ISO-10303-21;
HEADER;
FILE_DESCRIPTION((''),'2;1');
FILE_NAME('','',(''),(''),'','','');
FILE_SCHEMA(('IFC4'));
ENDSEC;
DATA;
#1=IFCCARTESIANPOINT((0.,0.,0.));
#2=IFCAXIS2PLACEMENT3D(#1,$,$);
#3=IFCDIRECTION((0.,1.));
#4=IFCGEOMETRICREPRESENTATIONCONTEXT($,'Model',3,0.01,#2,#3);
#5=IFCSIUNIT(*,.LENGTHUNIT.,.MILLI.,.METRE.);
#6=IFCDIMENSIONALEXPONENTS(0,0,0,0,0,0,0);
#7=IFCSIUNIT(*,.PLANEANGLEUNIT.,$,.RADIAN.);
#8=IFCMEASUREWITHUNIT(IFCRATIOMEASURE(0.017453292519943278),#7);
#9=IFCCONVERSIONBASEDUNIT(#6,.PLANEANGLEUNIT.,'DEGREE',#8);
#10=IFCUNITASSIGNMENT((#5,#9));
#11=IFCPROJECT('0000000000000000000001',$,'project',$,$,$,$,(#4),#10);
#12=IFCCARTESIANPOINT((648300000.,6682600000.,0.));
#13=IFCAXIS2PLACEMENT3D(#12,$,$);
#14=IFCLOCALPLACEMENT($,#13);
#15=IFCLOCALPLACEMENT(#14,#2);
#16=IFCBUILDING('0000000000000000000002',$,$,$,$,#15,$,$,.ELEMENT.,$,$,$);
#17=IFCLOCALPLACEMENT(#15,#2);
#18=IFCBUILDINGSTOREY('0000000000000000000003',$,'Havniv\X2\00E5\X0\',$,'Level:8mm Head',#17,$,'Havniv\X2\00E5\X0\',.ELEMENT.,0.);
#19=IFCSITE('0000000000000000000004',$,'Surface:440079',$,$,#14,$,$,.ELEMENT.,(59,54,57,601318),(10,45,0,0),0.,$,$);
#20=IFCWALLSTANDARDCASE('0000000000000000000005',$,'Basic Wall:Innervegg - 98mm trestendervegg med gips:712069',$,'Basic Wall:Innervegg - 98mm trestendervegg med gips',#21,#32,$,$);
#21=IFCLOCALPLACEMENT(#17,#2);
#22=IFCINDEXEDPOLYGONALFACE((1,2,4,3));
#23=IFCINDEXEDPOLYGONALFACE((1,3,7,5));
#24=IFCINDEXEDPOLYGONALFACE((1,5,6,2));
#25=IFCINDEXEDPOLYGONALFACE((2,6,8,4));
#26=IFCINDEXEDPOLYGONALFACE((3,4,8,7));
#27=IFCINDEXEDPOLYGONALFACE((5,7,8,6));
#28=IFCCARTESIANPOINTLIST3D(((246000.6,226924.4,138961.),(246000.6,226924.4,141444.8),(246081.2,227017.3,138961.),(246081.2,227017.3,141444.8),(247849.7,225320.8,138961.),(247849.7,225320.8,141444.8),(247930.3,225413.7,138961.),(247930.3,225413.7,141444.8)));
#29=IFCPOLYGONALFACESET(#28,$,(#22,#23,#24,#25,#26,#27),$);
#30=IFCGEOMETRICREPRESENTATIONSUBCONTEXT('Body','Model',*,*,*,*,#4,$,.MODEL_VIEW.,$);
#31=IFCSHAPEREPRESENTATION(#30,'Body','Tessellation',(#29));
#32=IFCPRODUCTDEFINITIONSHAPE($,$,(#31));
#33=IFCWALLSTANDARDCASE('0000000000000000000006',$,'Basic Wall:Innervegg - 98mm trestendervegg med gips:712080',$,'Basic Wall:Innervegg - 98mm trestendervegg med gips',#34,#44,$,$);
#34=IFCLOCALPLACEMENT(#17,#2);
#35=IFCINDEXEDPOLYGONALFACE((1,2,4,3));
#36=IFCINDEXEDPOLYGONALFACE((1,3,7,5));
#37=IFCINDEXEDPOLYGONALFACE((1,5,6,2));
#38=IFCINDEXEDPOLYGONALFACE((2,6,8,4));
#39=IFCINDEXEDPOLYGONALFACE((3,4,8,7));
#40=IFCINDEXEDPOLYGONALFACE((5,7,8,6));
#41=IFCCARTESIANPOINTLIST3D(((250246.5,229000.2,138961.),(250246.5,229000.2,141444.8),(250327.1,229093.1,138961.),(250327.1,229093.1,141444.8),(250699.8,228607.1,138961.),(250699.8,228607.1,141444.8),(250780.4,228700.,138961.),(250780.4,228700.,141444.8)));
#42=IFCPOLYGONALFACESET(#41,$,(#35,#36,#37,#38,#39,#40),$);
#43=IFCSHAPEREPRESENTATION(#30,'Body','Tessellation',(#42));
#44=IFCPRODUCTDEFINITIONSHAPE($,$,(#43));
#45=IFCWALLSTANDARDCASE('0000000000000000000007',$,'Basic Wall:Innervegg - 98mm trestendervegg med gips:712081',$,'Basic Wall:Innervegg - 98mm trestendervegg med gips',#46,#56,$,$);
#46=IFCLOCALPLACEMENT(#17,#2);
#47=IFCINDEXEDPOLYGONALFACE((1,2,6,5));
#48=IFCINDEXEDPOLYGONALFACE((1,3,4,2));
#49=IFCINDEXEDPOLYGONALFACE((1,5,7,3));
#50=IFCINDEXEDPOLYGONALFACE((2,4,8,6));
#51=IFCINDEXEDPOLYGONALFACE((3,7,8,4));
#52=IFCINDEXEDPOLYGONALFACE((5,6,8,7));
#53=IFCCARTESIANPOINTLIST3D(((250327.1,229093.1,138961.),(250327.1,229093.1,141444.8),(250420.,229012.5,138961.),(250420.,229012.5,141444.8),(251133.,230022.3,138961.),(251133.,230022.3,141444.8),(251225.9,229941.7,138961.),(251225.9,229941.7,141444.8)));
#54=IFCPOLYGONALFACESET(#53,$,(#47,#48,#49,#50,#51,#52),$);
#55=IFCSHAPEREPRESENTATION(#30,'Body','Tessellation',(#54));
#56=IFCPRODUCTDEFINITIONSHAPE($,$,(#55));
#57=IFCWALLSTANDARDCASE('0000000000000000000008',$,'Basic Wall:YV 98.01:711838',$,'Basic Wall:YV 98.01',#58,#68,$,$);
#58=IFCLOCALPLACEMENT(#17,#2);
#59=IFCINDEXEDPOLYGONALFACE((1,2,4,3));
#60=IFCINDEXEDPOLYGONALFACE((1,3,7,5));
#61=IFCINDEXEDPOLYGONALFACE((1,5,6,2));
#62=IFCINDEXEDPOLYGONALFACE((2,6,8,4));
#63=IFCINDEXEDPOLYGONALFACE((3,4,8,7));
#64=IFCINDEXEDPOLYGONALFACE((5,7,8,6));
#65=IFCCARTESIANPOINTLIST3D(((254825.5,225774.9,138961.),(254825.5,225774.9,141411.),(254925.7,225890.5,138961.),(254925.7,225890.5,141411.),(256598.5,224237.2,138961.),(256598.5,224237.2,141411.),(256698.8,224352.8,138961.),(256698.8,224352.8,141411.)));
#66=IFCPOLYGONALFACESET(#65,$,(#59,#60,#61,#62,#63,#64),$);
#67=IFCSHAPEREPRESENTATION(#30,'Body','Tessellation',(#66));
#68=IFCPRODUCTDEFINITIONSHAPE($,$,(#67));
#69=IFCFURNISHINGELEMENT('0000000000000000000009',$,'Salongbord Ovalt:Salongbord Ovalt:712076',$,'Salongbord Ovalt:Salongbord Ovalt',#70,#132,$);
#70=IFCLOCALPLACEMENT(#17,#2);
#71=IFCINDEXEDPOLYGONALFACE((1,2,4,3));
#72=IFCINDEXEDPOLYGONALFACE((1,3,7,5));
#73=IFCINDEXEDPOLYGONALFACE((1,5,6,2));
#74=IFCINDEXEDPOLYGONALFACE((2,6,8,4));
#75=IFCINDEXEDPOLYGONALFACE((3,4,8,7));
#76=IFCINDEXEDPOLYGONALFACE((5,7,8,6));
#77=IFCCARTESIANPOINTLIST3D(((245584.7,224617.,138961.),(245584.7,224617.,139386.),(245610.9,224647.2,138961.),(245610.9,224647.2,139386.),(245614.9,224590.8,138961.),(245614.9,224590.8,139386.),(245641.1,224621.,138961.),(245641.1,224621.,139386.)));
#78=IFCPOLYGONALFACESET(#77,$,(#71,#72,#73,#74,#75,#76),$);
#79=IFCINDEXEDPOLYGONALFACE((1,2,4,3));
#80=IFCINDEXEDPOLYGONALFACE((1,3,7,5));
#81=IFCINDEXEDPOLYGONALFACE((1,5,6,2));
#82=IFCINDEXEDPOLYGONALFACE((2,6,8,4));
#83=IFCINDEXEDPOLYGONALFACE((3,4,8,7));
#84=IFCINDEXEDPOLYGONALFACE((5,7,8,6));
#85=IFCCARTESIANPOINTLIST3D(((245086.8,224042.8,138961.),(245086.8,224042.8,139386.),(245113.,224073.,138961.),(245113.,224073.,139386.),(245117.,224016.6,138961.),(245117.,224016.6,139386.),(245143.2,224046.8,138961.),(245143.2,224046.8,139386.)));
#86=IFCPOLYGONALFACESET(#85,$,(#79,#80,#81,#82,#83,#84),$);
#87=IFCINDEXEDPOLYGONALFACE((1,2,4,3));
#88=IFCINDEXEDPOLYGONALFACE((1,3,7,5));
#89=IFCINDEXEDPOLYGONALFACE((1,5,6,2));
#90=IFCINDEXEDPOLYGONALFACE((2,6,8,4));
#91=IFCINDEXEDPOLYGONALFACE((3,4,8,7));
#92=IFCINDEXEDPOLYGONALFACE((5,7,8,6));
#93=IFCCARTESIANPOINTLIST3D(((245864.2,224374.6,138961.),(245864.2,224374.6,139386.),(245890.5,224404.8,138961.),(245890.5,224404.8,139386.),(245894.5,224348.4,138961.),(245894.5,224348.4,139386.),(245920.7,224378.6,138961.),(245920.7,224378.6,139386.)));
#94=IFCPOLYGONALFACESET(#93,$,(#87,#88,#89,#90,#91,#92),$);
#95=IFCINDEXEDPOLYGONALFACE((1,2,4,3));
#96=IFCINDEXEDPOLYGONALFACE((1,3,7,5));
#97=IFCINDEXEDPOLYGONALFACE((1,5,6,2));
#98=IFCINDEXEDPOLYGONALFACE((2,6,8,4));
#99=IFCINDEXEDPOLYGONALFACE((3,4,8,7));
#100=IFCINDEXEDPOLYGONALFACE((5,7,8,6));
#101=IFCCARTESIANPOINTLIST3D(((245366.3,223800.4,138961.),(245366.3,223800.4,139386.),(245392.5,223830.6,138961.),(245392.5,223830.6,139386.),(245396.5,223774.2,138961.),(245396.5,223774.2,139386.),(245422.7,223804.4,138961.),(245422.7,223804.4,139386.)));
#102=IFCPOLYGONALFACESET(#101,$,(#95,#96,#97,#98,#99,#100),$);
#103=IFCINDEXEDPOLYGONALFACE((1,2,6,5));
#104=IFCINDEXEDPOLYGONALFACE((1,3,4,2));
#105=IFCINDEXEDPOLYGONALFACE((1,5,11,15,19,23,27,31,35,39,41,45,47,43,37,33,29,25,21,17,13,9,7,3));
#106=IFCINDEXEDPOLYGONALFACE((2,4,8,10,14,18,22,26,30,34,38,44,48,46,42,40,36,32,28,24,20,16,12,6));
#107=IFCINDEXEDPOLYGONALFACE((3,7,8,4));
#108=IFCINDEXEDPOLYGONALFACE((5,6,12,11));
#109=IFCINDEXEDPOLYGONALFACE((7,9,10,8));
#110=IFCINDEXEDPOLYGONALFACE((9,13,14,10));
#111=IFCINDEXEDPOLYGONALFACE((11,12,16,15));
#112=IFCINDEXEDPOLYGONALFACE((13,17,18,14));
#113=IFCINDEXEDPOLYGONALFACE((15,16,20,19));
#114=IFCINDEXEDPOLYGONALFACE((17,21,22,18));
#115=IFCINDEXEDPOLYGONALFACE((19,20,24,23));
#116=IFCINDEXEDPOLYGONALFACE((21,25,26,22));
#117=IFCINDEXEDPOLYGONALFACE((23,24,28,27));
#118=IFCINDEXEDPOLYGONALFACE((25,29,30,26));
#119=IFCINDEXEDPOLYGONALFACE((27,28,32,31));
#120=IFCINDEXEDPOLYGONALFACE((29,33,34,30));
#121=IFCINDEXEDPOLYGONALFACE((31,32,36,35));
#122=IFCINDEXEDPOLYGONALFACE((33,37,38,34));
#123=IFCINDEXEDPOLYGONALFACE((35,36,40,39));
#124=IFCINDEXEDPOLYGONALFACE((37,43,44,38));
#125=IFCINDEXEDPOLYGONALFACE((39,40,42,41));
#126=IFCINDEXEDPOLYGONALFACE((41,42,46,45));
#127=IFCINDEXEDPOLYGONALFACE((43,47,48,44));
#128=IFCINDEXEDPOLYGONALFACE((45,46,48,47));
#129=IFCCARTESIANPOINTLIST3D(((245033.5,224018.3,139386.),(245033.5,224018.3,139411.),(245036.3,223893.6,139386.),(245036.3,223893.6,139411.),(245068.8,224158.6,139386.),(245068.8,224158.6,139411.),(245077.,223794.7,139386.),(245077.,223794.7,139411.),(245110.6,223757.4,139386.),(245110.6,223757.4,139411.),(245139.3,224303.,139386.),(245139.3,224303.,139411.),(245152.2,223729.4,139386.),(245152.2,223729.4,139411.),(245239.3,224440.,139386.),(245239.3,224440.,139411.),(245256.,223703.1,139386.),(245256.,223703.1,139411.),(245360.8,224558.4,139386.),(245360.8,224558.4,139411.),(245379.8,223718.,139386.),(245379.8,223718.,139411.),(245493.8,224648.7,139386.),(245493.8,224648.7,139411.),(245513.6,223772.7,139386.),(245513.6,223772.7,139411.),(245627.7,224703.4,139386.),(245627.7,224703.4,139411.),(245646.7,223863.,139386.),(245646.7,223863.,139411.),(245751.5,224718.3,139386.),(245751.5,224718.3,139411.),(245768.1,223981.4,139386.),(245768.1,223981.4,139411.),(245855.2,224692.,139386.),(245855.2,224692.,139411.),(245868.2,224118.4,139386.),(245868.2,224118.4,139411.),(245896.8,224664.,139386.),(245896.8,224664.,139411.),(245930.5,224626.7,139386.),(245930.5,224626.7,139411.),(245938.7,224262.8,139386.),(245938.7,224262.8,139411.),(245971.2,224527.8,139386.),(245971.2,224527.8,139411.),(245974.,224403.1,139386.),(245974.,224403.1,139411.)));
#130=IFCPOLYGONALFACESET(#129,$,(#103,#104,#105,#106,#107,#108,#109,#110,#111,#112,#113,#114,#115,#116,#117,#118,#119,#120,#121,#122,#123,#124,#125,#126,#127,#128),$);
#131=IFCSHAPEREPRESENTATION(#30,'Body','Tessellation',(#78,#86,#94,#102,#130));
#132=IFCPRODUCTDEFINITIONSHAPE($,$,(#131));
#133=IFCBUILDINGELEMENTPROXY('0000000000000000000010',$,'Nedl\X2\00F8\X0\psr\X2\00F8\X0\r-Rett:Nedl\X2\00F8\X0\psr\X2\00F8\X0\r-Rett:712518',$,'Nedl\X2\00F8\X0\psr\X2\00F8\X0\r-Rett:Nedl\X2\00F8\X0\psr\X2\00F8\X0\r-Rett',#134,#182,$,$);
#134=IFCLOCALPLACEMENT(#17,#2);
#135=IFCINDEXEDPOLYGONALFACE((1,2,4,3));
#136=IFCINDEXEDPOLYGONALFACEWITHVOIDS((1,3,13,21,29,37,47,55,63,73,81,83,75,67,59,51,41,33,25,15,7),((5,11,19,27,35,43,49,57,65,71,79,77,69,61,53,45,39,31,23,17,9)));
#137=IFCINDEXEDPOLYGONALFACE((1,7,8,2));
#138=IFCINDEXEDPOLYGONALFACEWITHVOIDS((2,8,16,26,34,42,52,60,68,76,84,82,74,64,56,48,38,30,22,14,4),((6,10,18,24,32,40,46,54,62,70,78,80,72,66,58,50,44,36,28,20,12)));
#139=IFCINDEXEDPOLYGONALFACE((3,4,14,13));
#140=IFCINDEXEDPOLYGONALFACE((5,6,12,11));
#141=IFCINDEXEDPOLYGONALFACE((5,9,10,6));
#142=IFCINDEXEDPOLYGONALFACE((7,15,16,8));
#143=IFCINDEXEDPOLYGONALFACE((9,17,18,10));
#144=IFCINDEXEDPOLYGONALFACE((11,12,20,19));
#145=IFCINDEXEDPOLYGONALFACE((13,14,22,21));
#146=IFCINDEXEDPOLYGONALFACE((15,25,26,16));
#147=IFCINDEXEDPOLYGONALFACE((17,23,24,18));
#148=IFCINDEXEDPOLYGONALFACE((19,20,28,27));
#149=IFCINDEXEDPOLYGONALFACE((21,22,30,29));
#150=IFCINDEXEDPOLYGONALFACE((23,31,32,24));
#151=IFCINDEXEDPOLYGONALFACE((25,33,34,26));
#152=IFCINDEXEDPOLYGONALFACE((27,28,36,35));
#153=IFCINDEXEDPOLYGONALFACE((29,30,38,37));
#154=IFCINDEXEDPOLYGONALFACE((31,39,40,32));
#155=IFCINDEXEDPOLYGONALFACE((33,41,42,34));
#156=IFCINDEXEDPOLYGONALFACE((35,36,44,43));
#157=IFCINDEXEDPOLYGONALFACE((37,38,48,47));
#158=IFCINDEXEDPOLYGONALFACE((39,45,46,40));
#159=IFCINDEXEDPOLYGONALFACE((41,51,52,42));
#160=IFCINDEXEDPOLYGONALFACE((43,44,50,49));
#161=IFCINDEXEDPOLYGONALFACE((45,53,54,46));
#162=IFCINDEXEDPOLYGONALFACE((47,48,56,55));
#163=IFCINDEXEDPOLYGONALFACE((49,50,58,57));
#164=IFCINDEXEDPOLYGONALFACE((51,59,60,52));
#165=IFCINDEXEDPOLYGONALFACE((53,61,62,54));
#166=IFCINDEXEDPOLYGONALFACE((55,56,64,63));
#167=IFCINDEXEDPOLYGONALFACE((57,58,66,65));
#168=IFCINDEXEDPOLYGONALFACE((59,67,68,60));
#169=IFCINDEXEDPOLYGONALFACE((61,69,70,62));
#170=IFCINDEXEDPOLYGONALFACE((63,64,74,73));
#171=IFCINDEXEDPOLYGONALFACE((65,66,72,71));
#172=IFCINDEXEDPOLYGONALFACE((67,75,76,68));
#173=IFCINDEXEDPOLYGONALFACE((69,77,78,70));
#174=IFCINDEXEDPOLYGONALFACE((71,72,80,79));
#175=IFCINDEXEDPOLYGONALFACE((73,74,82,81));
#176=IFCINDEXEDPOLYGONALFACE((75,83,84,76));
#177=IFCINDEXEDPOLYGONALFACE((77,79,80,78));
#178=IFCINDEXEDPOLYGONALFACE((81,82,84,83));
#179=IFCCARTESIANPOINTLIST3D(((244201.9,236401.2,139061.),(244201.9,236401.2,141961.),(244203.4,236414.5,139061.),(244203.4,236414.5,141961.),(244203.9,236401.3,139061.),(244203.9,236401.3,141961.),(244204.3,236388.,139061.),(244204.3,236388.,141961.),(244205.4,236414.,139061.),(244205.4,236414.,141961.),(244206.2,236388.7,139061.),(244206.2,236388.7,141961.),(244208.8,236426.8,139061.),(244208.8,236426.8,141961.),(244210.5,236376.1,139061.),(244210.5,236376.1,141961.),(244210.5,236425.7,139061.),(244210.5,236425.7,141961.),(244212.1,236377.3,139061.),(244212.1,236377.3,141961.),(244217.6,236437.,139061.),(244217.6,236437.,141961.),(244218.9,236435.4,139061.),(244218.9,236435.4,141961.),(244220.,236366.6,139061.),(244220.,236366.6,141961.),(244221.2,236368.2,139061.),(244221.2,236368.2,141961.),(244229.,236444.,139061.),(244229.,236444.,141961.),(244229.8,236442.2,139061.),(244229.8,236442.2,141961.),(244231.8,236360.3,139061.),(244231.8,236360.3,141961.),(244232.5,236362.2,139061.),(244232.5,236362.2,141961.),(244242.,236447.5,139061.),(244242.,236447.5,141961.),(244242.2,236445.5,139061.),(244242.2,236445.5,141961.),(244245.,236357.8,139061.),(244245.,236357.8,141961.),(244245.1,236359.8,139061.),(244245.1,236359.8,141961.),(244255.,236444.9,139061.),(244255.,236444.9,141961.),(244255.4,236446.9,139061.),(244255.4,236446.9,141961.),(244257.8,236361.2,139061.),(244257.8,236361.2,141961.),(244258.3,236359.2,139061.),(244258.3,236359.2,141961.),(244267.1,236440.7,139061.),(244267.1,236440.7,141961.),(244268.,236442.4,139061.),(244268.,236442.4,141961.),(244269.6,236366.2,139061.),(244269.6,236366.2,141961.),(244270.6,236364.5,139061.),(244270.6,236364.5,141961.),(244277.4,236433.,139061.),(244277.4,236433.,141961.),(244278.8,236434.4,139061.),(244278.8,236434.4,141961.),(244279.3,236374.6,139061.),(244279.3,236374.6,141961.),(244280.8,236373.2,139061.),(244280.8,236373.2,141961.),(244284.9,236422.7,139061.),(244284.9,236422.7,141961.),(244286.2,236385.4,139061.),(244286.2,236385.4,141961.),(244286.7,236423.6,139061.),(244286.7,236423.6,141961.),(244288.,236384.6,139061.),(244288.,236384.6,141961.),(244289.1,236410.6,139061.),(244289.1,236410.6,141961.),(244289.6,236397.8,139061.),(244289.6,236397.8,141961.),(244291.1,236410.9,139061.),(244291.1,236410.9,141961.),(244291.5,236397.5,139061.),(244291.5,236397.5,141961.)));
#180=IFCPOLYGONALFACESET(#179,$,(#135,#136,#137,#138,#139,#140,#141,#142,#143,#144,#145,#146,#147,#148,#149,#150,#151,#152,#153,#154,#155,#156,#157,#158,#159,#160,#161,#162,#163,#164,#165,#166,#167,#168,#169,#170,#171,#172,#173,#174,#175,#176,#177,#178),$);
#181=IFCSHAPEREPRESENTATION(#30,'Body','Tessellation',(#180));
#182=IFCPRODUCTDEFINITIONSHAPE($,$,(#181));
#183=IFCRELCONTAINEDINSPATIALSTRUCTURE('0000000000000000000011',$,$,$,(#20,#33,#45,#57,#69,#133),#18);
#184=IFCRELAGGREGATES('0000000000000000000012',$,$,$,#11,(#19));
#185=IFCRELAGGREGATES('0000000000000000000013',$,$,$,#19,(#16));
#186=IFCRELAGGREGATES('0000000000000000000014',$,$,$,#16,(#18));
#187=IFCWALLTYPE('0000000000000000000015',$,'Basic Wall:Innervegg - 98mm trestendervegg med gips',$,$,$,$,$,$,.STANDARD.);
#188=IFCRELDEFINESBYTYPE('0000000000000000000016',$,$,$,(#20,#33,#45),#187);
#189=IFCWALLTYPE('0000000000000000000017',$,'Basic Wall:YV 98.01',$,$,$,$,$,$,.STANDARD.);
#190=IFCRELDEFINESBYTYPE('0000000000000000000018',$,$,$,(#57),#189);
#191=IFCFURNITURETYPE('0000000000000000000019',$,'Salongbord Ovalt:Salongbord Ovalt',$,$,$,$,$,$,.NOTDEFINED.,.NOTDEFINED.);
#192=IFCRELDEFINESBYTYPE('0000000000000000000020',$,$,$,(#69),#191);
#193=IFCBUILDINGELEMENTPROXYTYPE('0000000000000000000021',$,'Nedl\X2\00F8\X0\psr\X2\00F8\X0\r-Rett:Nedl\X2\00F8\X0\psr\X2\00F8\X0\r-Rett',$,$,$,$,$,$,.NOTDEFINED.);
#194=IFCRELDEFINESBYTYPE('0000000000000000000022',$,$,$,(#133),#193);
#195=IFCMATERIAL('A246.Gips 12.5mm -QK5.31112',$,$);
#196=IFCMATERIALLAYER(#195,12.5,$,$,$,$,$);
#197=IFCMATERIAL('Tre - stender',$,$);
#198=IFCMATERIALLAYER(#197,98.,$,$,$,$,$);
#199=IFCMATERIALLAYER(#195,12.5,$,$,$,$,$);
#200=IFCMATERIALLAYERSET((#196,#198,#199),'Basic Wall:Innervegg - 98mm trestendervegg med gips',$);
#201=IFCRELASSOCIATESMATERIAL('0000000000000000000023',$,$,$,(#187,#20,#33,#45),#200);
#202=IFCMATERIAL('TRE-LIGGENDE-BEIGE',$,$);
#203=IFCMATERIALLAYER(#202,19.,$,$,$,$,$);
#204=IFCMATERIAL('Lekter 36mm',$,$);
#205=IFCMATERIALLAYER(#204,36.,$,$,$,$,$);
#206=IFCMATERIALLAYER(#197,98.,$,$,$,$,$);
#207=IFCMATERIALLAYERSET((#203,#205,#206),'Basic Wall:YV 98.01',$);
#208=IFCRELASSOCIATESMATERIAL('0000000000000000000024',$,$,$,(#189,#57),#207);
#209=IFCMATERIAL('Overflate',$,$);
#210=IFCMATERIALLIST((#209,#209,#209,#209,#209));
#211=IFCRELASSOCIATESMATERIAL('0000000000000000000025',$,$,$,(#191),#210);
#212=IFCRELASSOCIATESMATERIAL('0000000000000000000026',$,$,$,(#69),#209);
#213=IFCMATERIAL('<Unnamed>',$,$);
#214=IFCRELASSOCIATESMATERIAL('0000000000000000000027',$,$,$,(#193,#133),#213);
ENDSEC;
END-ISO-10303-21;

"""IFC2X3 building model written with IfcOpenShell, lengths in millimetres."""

from ifc_helpers import new_model, entity, si_unit, converted_unit, direction, frame, frame_2d, origin, origin_2d_with_axis, place, context, subcontext, project, spatial, polyline, rectangle, hollow_circle, outline, extrude, source, transform, mapped, material, material_list, layer, layer_set, layer_usage, type_object, type_shapes, element, save


model = new_model("IFC2X3")

# Units and contexts
model_context = context("Model", 3, precision=0.01, world=origin(), true_north=direction((0.0, 1.0)))
body_context = subcontext(model_context, "Body", "Model", "MODEL_VIEW")
ifc_project = project(units=[si_unit("LENGTHUNIT", "METRE", prefix="MILLI"), converted_unit("PLANEANGLEUNIT", "DEGREE", entity("IfcRatioMeasure", 0.017453292519943278), si_unit("PLANEANGLEUNIT", "RADIAN"), dimensions=[0, 0, 0, 0, 0, 0, 0])], contexts=[model_context])

# Site, building, storey
site_placement = place(None, frame((648300000.0, 6682600000.0, 0.0)))
site = spatial("IfcSite", under=ifc_project, at=site_placement, Name="Surface:440079", CompositionType="ELEMENT", RefLatitude=(59, 54, 57, 601318), RefLongitude=(10, 45, 0, 0), RefElevation=0.0)
building_placement = place(site_placement, origin())
building = spatial("IfcBuilding", under=site, at=building_placement, CompositionType="ELEMENT")
storey_placement = place(building_placement, origin())
storey = spatial("IfcBuildingStorey", under=building, at=storey_placement, Name="Havnivå", ObjectType="Level:8mm Head", LongName="Havnivå", CompositionType="ELEMENT", Elevation=0.0)

# Shared definitions
ifc_material_1 = material(Name="A246.Gips 12.5mm -QK5.31112")
ifc_layer_1 = layer(ifc_material_1, 12.5)
ifc_material_2 = material(Name="Tre - stender")
ifc_layer_2 = layer(ifc_material_2, 98.0)
ifc_layer_3 = layer(ifc_material_1, 12.5)
ifc_layer_set_1 = layer_set([ifc_layer_1, ifc_layer_2, ifc_layer_3], Name="Basic Wall:Innervegg - 98mm trestendervegg med gips")
wall_type_1 = type_object("IfcWallType", Name="Basic Wall:Innervegg - 98mm trestendervegg med gips", PredefinedType="STANDARD", material=ifc_layer_set_1)

# Walls
ifc_layer_usage_1 = layer_usage(ifc_layer_set_1, "AXIS2", "NEGATIVE", 61.5)
wall_1_placement = place(storey_placement, frame((247890.0, 225367.2, 138961.0), z_axis=(0.0, 0.0, 1.0), x_axis=(-0.755467, 0.655187, 0.0)))
element("IfcWallStandardCase", 1, at=wall_1_placement, inside=storey, type_object=wall_type_1, material=ifc_layer_usage_1, Name="Basic Wall:Innervegg - 98mm trestendervegg med gips:712069", ObjectType="Basic Wall:Innervegg - 98mm trestendervegg med gips", context=body_context, shape_type="SweptSolid", body=[
    extrude(rectangle(XDim=2447.6, YDim=123.0, at=frame_2d((1223.8, 0.0), x_axis=(-1.0, 0.0))), origin(), (0.0, 0.0, 1.0), 2483.8),
])
ifc_layer_usage_2 = layer_usage(ifc_layer_set_1, "AXIS2", "POSITIVE", -61.5)
wall_2_placement = place(storey_placement, frame((250740.1, 228653.5, 138961.0), z_axis=(0.0, 0.0, 1.0), x_axis=(-0.755467, 0.655187, 0.0)))
element("IfcWallStandardCase", 2, at=wall_2_placement, inside=storey, type_object=wall_type_1, material=ifc_layer_usage_2, Name="Basic Wall:Innervegg - 98mm trestendervegg med gips:712080", ObjectType="Basic Wall:Innervegg - 98mm trestendervegg med gips", context=body_context, shape_type="SweptSolid", body=[
    extrude(rectangle(XDim=600.0, YDim=123.0, at=frame_2d((300.0, 0.0), x_axis=(-1.0, 0.0))), origin(), (0.0, 0.0, 1.0), 2483.8),
])
ifc_layer_usage_3 = layer_usage(ifc_layer_set_1, "AXIS2", "POSITIVE", -61.5)
wall_3_placement = place(storey_placement, frame((250373.5, 229052.8, 138961.0), z_axis=(0.0, 0.0, 1.0), x_axis=(0.655187, 0.755467, 0.0)))
element("IfcWallStandardCase", 3, at=wall_3_placement, inside=storey, type_object=wall_type_1, material=ifc_layer_usage_3, Name="Basic Wall:Innervegg - 98mm trestendervegg med gips:712081", ObjectType="Basic Wall:Innervegg - 98mm trestendervegg med gips", context=body_context, shape_type="SweptSolid", body=[
    extrude(rectangle(XDim=1230.0, YDim=123.0, at=frame_2d((615.0, 0.0), x_axis=(-1.0, 0.0))), origin(), (0.0, 0.0, 1.0), 2483.8),
])
ifc_material_3 = material(Name="TRE-LIGGENDE-BEIGE")
ifc_layer_4 = layer(ifc_material_3, 19.0)
ifc_material_4 = material(Name="Lekter 36mm")
ifc_layer_5 = layer(ifc_material_4, 36.0)
ifc_layer_6 = layer(ifc_material_2, 98.0)
ifc_layer_set_2 = layer_set([ifc_layer_4, ifc_layer_5, ifc_layer_6], Name="Basic Wall:YV 98.01")
ifc_layer_usage_4 = layer_usage(ifc_layer_set_2, "AXIS2", "NEGATIVE", 76.5)
wall_type_2 = type_object("IfcWallType", Name="Basic Wall:YV 98.01", PredefinedType="STANDARD", material=ifc_layer_set_2)
wall_4_placement = place(storey_placement, frame((254875.6, 225832.7, 138961.0), z_axis=(0.0, 0.0, 1.0), x_axis=(0.755467, -0.655187, 0.0)))
element("IfcWallStandardCase", 4, at=wall_4_placement, inside=storey, type_object=wall_type_2, material=ifc_layer_usage_4, Name="Basic Wall:YV 98.01:711838", ObjectType="Basic Wall:YV 98.01", context=body_context, shape_type="SweptSolid", body=[
    extrude(rectangle(XDim=2347.0, YDim=153.0, at=frame_2d((1173.5, 0.0), x_axis=(-1.0, 0.0))), origin(), (0.0, 0.0, 1.0), 2450.0),
])

# Furnishing element
ifc_material_5 = material(Name="Overflate")
ifc_material_list_1 = material_list([ifc_material_5, ifc_material_5, ifc_material_5, ifc_material_5, ifc_material_5])
furniture_type_1 = type_object("IfcFurnitureType", Name="Salongbord Ovalt:Salongbord Ovalt", material=ifc_material_list_1)
shared_shape_1 = source(origin(), body_context, "Body", "SweptSolid", [
    extrude(rectangle(XDim=40.0, YDim=40.0, at=origin_2d_with_axis()), frame((380.0, 185.0, 0.0), z_axis=(0.0, 0.0, 1.0), x_axis=(-1.0, 0.0, 0.0)), (0.0, 0.0, 1.0), 425.0),
    extrude(rectangle(XDim=40.0, YDim=40.0, at=origin_2d_with_axis()), frame((-380.0, 185.0, 0.0), z_axis=(0.0, 0.0, 1.0), x_axis=(-1.0, 0.0, 0.0)), (0.0, 0.0, 1.0), 425.0),
    extrude(rectangle(XDim=40.0, YDim=40.0, at=origin_2d_with_axis()), frame((380.0, -185.0, 0.0), z_axis=(0.0, 0.0, 1.0), x_axis=(-1.0, 0.0, 0.0)), (0.0, 0.0, 1.0), 425.0),
    extrude(rectangle(XDim=40.0, YDim=40.0, at=origin_2d_with_axis()), frame((-380.0, -185.0, 0.0), z_axis=(0.0, 0.0, 1.0), x_axis=(-1.0, 0.0, 0.0)), (0.0, 0.0, 1.0), 425.0),
    extrude(outline(polyline([(-73.0, -595.5), (-22.8, -595.5), (77.9, -559.4), (172.3, -478.0), (252.8, -357.8), (312.8, -208.7), (347.4, -42.6), (353.9, 126.9), (331.7, 286.1), (282.7, 422.2), (210.7, 524.0), (121.7, 583.4), (73.0, 595.5), (22.8, 595.5), (-77.9, 559.4), (-172.3, 478.0), (-252.8, 357.8), (-312.8, 208.7), (-347.4, 42.6), (-353.9, -126.9), (-331.7, -286.1), (-282.7, -422.2), (-210.7, -524.0), (-121.7, -583.4), (-73.0, -595.5)])), frame((0.0, 0.0, 425.0), z_axis=(0.0, 0.0, 1.0), x_axis=(0.121697, -0.992567, 0.0)), (0.0, 0.0, 1.0), 25.0),
])
type_shapes(furniture_type_1, [shared_shape_1])
furnishing_1_placement = place(storey_placement, frame((245503.7, 224210.7, 138961.0), z_axis=(0.0, 0.0, 1.0), x_axis=(0.655187, 0.755467, 0.0)))
element("IfcFurnishingElement", 5, at=furnishing_1_placement, inside=storey, type_object=furniture_type_1, material=ifc_material_5, Name="Salongbord Ovalt:Salongbord Ovalt:712076", ObjectType="Salongbord Ovalt:Salongbord Ovalt", context=body_context, shape_type="MappedRepresentation", body=[
    mapped(shared_shape_1, transform((0.0, 0.0, 0.0), scale=1.0)),
])

# Building element proxy
ifc_material_6 = material(Name="<Unnamed>")
building_element_proxy_type_1 = type_object("IfcBuildingElementProxyType", Name="Nedløpsrør-Rett:Nedløpsrør-Rett", PredefinedType="NOTDEFINED", material=ifc_material_6)
shared_shape_2 = source(origin(), body_context, "Body", "SweptSolid", [
    extrude(hollow_circle(Radius=45.0, WallThickness=2.0, at=frame_2d((0.0, 0.0), x_axis=(1.0, 0.0))), frame((0.0, 0.0, 0.0), z_axis=(0.0, 0.0, 1.0), x_axis=(-1.0, 0.0, 0.0)), (0.0, 0.0, 1.0), 2900.0),
])
type_shapes(building_element_proxy_type_1, [shared_shape_2])
proxy_1_placement = place(storey_placement, frame((244246.8, 236402.7, 139061.0), z_axis=(0.0, 0.0, 1.0), x_axis=(-0.755467, 0.655187, 0.0)))
element("IfcBuildingElementProxy", 6, at=proxy_1_placement, inside=storey, type_object=building_element_proxy_type_1, material=ifc_material_6, Name="Nedløpsrør-Rett:Nedløpsrør-Rett:712518", ObjectType="Nedløpsrør-Rett:Nedløpsrør-Rett", context=body_context, shape_type="MappedRepresentation", body=[
    mapped(shared_shape_2, transform((0.0, 0.0, 0.0), scale=1.0)),
])

save(model, "model.ifc")
